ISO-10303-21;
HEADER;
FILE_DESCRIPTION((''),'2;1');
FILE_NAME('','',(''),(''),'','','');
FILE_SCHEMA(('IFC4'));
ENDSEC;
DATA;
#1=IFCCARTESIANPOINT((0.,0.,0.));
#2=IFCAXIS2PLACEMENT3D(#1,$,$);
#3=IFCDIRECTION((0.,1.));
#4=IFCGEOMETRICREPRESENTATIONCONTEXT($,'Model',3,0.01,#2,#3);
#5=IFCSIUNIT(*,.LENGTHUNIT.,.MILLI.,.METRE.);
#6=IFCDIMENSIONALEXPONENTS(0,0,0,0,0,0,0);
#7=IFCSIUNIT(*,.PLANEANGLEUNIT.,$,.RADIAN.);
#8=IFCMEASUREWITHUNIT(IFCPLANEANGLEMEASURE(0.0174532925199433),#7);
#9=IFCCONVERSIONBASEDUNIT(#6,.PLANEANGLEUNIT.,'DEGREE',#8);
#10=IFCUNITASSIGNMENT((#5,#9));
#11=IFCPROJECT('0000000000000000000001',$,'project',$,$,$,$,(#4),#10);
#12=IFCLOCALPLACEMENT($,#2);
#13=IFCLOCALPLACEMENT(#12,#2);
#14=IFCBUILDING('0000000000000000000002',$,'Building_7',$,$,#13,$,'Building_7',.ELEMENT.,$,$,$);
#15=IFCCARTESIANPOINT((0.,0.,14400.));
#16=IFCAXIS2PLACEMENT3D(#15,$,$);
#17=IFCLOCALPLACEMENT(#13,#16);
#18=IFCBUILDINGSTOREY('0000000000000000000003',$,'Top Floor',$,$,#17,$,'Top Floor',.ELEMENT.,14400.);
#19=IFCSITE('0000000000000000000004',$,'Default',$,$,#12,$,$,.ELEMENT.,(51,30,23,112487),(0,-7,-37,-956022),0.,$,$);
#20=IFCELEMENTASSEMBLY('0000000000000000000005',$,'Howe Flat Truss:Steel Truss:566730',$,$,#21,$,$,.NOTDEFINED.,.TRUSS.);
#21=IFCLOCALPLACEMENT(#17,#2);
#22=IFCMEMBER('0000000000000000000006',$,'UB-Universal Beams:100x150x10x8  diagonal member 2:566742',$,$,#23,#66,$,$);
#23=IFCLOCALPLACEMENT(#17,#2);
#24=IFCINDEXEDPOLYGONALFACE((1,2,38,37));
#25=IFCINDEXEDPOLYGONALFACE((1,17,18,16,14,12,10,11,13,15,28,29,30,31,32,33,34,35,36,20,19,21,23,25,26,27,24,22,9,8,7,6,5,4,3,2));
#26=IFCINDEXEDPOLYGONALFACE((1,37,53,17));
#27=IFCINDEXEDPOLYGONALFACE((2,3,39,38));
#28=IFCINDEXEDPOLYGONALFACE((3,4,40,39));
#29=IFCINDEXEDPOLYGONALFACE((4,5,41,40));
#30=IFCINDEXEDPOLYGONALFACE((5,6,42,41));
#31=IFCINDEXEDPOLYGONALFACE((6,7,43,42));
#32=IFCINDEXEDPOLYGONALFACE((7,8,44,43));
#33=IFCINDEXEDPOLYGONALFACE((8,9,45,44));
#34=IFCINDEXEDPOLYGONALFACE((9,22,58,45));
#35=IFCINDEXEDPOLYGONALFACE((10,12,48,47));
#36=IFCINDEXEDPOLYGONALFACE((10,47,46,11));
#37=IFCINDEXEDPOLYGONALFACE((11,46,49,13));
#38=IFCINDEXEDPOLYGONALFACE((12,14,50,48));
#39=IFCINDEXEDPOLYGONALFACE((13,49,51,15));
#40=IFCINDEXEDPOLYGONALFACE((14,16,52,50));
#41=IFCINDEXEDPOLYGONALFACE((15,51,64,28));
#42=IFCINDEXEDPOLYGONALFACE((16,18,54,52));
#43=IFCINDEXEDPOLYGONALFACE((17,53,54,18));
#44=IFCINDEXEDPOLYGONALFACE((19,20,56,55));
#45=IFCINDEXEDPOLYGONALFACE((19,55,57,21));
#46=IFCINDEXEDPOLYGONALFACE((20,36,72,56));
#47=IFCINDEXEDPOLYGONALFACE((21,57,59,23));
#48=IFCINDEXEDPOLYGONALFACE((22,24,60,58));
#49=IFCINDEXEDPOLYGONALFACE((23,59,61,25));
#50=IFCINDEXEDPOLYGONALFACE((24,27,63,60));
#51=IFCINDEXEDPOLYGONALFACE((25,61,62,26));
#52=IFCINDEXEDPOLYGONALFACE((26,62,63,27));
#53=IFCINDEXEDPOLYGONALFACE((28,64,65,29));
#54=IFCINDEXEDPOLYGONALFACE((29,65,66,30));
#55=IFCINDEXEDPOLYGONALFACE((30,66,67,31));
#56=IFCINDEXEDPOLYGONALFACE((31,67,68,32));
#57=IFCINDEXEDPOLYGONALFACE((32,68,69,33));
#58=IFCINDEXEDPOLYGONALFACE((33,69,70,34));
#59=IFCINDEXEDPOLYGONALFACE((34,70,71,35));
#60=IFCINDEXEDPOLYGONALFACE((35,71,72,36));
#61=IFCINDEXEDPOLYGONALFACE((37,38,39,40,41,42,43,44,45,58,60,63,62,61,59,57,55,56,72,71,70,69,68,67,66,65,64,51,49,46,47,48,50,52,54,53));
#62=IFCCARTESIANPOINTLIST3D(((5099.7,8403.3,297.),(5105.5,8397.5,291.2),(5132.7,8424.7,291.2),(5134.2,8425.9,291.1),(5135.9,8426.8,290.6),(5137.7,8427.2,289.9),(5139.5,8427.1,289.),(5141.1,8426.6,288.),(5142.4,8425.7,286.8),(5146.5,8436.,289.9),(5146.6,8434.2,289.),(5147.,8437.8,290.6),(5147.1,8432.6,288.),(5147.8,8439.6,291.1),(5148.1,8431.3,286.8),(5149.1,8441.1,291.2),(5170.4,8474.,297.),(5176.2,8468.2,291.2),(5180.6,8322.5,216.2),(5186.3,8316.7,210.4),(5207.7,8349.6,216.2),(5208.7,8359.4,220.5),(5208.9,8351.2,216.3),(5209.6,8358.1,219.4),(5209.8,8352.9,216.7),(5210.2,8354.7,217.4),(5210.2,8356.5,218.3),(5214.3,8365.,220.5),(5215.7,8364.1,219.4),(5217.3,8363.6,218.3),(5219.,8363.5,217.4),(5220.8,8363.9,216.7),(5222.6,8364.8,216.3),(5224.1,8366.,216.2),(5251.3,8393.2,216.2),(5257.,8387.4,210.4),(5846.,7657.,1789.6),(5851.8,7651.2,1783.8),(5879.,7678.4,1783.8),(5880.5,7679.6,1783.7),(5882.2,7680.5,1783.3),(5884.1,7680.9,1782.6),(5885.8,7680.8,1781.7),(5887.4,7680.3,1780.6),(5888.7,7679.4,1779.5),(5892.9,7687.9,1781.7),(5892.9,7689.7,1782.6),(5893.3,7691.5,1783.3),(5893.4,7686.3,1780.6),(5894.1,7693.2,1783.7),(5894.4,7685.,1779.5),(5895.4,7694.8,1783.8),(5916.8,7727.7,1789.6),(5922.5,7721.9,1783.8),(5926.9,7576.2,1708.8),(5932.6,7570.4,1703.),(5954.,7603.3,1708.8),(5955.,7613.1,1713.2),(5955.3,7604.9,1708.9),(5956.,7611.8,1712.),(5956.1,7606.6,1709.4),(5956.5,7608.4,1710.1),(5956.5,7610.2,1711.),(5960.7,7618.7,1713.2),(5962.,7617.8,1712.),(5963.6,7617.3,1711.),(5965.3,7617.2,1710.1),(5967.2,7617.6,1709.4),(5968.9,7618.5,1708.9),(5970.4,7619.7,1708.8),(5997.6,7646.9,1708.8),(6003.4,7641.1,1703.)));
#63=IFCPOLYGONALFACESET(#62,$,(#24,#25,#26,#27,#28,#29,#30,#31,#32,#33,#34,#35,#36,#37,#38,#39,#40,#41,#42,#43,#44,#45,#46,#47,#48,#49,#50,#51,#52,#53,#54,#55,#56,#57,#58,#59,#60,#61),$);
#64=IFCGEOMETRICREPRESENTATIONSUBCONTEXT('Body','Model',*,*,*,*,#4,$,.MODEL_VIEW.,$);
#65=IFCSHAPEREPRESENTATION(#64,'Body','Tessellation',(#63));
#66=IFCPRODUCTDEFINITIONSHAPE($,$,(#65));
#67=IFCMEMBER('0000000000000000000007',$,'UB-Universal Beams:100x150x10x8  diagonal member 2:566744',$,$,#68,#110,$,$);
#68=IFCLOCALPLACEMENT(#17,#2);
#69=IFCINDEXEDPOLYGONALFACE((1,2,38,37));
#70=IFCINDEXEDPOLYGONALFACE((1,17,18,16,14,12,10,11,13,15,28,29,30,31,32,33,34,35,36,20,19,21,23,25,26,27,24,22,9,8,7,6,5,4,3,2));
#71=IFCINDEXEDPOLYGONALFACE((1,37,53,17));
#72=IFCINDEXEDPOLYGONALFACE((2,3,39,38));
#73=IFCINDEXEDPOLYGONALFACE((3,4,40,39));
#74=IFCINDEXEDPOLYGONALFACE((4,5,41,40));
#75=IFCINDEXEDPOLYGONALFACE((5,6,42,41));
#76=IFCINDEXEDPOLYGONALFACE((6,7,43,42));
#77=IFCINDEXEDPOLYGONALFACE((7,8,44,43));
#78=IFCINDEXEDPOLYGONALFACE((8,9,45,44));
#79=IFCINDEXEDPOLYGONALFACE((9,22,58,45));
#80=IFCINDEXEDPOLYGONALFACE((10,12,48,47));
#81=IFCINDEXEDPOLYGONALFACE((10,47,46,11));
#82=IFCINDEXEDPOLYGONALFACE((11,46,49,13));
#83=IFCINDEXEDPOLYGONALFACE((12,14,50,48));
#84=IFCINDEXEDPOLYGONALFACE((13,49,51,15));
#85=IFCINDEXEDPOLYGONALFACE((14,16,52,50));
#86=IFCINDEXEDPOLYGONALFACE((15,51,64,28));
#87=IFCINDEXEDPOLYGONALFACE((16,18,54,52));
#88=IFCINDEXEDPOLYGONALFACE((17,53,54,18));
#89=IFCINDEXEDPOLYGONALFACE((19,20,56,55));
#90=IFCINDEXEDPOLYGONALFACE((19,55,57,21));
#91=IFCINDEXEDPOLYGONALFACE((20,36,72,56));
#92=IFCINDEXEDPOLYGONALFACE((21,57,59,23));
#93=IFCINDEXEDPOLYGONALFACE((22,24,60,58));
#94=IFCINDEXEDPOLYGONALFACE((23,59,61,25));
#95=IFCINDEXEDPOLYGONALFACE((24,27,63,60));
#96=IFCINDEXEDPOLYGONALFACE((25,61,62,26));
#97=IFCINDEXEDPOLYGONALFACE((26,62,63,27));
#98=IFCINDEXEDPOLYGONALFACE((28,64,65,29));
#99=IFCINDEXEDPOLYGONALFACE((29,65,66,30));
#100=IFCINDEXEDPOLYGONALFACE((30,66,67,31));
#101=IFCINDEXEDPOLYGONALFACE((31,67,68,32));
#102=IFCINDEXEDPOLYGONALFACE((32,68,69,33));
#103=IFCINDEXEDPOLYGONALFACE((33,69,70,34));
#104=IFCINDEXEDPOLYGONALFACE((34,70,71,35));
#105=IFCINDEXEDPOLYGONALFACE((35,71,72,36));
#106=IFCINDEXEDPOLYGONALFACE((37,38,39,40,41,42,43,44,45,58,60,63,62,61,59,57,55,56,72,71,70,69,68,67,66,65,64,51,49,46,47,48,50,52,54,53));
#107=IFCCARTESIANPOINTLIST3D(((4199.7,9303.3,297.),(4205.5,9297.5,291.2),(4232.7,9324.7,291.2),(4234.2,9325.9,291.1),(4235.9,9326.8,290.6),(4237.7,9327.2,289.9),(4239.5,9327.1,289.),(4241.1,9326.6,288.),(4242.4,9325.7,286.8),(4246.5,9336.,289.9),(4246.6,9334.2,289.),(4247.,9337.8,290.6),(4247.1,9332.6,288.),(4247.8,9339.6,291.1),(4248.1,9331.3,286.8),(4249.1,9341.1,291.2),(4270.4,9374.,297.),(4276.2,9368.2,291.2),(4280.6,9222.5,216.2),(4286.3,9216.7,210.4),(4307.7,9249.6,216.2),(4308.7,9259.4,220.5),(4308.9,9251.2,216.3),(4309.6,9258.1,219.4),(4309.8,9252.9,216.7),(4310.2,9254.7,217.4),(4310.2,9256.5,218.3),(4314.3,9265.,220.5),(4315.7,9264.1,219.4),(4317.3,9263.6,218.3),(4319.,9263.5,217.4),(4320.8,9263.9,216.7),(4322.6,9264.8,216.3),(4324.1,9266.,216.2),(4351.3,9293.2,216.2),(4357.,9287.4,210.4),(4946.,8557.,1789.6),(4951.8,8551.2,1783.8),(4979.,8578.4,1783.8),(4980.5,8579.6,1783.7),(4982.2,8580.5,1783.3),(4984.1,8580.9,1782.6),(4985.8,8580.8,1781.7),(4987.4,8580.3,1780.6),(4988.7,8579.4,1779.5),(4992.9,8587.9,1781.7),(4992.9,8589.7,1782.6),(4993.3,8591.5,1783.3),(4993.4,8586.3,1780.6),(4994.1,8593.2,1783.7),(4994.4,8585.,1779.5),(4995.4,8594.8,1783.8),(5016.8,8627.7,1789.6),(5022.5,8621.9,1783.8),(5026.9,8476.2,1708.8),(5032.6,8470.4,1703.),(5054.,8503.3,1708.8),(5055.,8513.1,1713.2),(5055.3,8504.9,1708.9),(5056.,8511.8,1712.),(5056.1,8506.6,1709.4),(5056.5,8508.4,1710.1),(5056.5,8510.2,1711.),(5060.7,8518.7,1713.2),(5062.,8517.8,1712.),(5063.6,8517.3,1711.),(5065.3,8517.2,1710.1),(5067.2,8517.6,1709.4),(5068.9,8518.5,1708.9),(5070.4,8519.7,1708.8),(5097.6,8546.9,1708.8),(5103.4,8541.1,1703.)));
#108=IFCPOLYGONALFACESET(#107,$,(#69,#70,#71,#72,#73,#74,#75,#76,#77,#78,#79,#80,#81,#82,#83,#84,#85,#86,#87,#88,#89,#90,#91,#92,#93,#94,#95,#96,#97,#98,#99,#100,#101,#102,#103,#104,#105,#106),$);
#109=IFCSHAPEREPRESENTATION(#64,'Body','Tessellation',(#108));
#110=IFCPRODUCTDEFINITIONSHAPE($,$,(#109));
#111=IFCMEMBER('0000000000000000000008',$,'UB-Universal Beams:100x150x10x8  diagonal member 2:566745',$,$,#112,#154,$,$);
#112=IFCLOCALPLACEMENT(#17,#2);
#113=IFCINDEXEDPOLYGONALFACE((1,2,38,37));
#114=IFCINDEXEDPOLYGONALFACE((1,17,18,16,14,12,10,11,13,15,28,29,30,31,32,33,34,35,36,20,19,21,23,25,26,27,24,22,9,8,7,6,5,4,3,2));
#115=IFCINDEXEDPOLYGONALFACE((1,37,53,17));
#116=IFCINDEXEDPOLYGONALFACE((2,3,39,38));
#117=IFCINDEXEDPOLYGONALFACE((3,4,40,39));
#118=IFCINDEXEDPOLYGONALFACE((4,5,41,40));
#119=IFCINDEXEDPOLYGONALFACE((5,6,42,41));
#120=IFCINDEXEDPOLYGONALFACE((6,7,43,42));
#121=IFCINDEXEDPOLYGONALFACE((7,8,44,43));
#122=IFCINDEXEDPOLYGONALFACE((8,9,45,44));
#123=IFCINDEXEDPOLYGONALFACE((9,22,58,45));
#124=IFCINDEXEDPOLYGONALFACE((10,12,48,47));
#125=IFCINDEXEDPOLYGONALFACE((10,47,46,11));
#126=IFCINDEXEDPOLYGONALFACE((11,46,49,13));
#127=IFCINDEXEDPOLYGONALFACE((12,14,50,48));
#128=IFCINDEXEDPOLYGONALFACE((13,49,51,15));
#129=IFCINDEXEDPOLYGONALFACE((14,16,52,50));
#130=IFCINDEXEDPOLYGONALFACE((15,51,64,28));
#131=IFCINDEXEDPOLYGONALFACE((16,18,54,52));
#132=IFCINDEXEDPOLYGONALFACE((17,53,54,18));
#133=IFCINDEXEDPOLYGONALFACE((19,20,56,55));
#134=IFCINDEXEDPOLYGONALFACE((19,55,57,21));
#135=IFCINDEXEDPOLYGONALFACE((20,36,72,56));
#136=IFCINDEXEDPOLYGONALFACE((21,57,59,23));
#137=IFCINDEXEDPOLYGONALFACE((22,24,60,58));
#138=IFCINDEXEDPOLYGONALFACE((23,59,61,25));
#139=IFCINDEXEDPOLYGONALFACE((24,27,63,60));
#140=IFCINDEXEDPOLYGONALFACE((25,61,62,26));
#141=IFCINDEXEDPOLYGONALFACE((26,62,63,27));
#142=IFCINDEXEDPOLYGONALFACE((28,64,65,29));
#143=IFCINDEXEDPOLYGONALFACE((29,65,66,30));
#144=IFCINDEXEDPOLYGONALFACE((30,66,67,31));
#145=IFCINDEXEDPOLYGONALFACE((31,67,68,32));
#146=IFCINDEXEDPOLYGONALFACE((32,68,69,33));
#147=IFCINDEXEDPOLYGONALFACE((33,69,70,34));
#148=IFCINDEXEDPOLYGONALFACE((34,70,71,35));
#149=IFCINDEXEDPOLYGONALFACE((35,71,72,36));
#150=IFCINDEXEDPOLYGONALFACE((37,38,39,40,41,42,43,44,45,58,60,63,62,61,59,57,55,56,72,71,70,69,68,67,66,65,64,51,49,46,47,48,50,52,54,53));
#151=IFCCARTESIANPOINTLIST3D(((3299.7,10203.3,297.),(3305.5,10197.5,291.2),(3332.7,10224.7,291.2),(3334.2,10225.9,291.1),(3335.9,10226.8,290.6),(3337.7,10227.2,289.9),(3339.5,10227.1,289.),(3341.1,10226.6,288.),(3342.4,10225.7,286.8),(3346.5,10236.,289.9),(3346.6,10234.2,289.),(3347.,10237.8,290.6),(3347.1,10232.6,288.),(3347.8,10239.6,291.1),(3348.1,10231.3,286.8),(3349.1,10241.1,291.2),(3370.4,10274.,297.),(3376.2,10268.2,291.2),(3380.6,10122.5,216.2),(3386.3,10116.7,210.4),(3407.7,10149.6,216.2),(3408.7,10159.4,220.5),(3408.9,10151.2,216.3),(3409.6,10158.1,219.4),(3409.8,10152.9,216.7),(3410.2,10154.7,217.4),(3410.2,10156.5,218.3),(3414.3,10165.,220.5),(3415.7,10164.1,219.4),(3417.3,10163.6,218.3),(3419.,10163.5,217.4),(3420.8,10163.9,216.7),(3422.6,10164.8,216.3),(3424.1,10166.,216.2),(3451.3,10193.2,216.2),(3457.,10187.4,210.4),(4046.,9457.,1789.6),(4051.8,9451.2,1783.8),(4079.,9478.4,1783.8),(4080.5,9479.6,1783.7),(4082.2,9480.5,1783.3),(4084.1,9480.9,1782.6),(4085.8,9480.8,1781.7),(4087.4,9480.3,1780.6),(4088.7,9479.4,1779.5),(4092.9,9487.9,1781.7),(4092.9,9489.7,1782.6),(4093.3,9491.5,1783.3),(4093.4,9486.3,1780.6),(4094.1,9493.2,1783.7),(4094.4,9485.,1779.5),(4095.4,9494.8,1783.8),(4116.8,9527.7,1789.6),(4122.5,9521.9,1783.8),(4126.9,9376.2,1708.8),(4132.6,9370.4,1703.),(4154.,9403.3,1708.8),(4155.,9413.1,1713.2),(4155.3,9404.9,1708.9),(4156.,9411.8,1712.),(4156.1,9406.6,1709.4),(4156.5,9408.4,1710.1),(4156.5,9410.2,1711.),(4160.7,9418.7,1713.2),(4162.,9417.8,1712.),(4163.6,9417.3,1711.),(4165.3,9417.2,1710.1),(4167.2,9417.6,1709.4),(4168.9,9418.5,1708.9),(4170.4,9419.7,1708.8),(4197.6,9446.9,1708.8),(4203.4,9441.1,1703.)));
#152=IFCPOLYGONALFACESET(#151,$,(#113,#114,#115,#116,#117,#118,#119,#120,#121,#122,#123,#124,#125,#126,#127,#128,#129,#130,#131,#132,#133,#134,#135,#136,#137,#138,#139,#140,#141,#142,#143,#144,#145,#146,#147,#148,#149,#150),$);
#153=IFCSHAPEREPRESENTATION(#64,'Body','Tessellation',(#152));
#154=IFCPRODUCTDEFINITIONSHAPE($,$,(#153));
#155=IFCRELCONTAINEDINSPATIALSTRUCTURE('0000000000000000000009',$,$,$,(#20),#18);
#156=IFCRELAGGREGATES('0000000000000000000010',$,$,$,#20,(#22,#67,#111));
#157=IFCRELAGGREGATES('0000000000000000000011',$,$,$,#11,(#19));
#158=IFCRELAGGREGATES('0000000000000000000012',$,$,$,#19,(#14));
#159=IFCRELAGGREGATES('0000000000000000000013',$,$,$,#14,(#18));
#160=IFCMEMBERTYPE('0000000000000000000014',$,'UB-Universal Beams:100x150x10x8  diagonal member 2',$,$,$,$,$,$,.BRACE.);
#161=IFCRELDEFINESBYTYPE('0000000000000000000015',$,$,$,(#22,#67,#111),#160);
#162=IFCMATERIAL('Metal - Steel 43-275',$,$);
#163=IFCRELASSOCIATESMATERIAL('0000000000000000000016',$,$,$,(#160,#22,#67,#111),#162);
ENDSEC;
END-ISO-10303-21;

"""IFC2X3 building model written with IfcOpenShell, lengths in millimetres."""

from ifc_helpers import new_model, entity, si_unit, converted_unit, direction, frame, frame_2d, origin, place, context, subcontext, project, spatial, polyline, circle_curve, parameter, trimmed, segment, composite_curve, outline, extrude, source, transform, mapped, material, type_object, type_shapes, element, aggregate, save


model = new_model("IFC2X3")

# Units and contexts
model_context = context("Model", 3, precision=0.01, world=origin(), true_north=direction((0.0, 1.0)))
body_context = subcontext(model_context, "Body", "Model", "MODEL_VIEW")
ifc_project = project(units=[si_unit("LENGTHUNIT", "METRE", prefix="MILLI"), converted_unit("PLANEANGLEUNIT", "DEGREE", entity("IfcPlaneAngleMeasure", 0.0174532925199433), si_unit("PLANEANGLEUNIT", "RADIAN"), dimensions=[0, 0, 0, 0, 0, 0, 0])], contexts=[model_context])

# Site, building, storey
site_placement = place(None, origin())
site = spatial("IfcSite", under=ifc_project, at=site_placement, Name="Default", CompositionType="ELEMENT", RefLatitude=(51, 30, 23, 112487), RefLongitude=(0, -7, -37, -956022), RefElevation=0.0)
building_placement = place(site_placement, origin())
building = spatial("IfcBuilding", under=site, at=building_placement, Name="Building_7", LongName="Building_7", CompositionType="ELEMENT")
storey_placement = place(building_placement, frame((0.0, 0.0, 14400.0)))
storey = spatial("IfcBuildingStorey", under=building, at=storey_placement, Name="Top Floor", LongName="Top Floor", CompositionType="ELEMENT", Elevation=14400.0)

# Shared definitions
ifc_material = material(Name="Metal - Steel 43-275")

# Element assembly
assembly_1_placement = place(storey_placement, origin())
assembly_1 = element("IfcElementAssembly", 1, at=assembly_1_placement, inside=storey, Name="Howe Flat Truss:Steel Truss:566730", AssemblyPlace="NOTDEFINED", PredefinedType="TRUSS")

# Members
member_type_1 = type_object("IfcMemberType", Name="UB-Universal Beams:100x150x10x8  diagonal member 2", PredefinedType="BRACE", material=ifc_material)
shared_shape_1 = source(origin(), body_context, "Body", "SweptSolid", [
    extrude(outline(composite_curve([segment(polyline([(-50.0, -65.0), (-50.0, -75.0)]), True, "CONTINUOUS"), segment(polyline([(-50.0, -75.0), (50.0, -75.0)]), True, "CONTINUOUS"), segment(polyline([(50.0, -75.0), (50.0, -65.0)]), True, "CONTINUOUS"), segment(polyline([(50.0, -65.0), (11.6, -65.0)]), True, "CONTINUOUS"), segment(trimmed(circle_curve(frame_2d((11.6, -57.4), x_axis=(1.0, 0.0)), 7.6), [parameter(180.0)], [parameter(270.0)], True, "PARAMETER"), False, "CONTINUOUS"), segment(polyline([(4.0, -57.4), (4.0, 57.4)]), True, "CONTINUOUS"), segment(trimmed(circle_curve(frame_2d((11.6, 57.4), x_axis=(1.0, 0.0)), 7.6), [parameter(90.0)], [parameter(180.0)], True, "PARAMETER"), False, "CONTINUOUS"), segment(polyline([(11.6, 65.0), (50.0, 65.0)]), True, "CONTINUOUS"), segment(polyline([(50.0, 65.0), (50.0, 75.0)]), True, "CONTINUOUS"), segment(polyline([(50.0, 75.0), (-50.0, 75.0)]), True, "CONTINUOUS"), segment(polyline([(-50.0, 75.0), (-50.0, 65.0)]), True, "CONTINUOUS"), segment(polyline([(-50.0, 65.0), (-11.6, 65.0)]), True, "CONTINUOUS"), segment(trimmed(circle_curve(frame_2d((-11.6, 57.4), x_axis=(1.0, 0.0)), 7.6), [parameter(360.0)], [parameter(90.0)], True, "PARAMETER"), False, "CONTINUOUS"), segment(polyline([(-4.0, 57.4), (-4.0, -57.4)]), True, "CONTINUOUS"), segment(trimmed(circle_curve(frame_2d((-11.6, -57.4), x_axis=(1.0, 0.0)), 7.6), [parameter(270.0)], [parameter(360.0)], True, "PARAMETER"), False, "CONTINUOUS"), segment(polyline([(-11.6, -65.0), (-50.0, -65.0)]), True, "CONTINUOUS")], self_intersect=False)), frame((-914.0, 0.0, 0.0), z_axis=(-1.0, 0.0, 0.0), x_axis=(0.0, -1.0, 0.0)), (0.0, 0.0, -1.0), 1828.1),
])
type_shapes(member_type_1, [shared_shape_1])
member_1_placement = place(assembly_1_placement, frame((5551.5, 8022.2, 1000.0), z_axis=(0.57735, -0.57735, -0.57735), x_axis=(0.408248, -0.408248, 0.816497)))
member_1 = element("IfcMember", 2, at=member_1_placement, type_object=member_type_1, material=ifc_material, Name="UB-Universal Beams:100x150x10x8  diagonal member 2:566742", context=body_context, shape_type="MappedRepresentation", body=[
    mapped(shared_shape_1, transform((0.0, 0.0, 0.0), scale=1.0)),
])
member_2_placement = place(assembly_1_placement, frame((4651.5, 8922.2, 1000.0), z_axis=(0.57735, -0.57735, -0.57735), x_axis=(0.408248, -0.408248, 0.816497)))
member_2 = element("IfcMember", 3, at=member_2_placement, type_object=member_type_1, material=ifc_material, Name="UB-Universal Beams:100x150x10x8  diagonal member 2:566744", context=body_context, shape_type="MappedRepresentation", body=[
    mapped(shared_shape_1, transform((0.0, 0.0, 0.0), scale=1.0)),
])
member_3_placement = place(assembly_1_placement, frame((3751.5, 9822.2, 1000.0), z_axis=(0.57735, -0.57735, -0.57735), x_axis=(0.408248, -0.408248, 0.816497)))
member_3 = element("IfcMember", 4, at=member_3_placement, type_object=member_type_1, material=ifc_material, Name="UB-Universal Beams:100x150x10x8  diagonal member 2:566745", context=body_context, shape_type="MappedRepresentation", body=[
    mapped(shared_shape_1, transform((0.0, 0.0, 0.0), scale=1.0)),
])
aggregate(assembly_1, [member_1, member_2, member_3])

save(model, "model.ifc")
